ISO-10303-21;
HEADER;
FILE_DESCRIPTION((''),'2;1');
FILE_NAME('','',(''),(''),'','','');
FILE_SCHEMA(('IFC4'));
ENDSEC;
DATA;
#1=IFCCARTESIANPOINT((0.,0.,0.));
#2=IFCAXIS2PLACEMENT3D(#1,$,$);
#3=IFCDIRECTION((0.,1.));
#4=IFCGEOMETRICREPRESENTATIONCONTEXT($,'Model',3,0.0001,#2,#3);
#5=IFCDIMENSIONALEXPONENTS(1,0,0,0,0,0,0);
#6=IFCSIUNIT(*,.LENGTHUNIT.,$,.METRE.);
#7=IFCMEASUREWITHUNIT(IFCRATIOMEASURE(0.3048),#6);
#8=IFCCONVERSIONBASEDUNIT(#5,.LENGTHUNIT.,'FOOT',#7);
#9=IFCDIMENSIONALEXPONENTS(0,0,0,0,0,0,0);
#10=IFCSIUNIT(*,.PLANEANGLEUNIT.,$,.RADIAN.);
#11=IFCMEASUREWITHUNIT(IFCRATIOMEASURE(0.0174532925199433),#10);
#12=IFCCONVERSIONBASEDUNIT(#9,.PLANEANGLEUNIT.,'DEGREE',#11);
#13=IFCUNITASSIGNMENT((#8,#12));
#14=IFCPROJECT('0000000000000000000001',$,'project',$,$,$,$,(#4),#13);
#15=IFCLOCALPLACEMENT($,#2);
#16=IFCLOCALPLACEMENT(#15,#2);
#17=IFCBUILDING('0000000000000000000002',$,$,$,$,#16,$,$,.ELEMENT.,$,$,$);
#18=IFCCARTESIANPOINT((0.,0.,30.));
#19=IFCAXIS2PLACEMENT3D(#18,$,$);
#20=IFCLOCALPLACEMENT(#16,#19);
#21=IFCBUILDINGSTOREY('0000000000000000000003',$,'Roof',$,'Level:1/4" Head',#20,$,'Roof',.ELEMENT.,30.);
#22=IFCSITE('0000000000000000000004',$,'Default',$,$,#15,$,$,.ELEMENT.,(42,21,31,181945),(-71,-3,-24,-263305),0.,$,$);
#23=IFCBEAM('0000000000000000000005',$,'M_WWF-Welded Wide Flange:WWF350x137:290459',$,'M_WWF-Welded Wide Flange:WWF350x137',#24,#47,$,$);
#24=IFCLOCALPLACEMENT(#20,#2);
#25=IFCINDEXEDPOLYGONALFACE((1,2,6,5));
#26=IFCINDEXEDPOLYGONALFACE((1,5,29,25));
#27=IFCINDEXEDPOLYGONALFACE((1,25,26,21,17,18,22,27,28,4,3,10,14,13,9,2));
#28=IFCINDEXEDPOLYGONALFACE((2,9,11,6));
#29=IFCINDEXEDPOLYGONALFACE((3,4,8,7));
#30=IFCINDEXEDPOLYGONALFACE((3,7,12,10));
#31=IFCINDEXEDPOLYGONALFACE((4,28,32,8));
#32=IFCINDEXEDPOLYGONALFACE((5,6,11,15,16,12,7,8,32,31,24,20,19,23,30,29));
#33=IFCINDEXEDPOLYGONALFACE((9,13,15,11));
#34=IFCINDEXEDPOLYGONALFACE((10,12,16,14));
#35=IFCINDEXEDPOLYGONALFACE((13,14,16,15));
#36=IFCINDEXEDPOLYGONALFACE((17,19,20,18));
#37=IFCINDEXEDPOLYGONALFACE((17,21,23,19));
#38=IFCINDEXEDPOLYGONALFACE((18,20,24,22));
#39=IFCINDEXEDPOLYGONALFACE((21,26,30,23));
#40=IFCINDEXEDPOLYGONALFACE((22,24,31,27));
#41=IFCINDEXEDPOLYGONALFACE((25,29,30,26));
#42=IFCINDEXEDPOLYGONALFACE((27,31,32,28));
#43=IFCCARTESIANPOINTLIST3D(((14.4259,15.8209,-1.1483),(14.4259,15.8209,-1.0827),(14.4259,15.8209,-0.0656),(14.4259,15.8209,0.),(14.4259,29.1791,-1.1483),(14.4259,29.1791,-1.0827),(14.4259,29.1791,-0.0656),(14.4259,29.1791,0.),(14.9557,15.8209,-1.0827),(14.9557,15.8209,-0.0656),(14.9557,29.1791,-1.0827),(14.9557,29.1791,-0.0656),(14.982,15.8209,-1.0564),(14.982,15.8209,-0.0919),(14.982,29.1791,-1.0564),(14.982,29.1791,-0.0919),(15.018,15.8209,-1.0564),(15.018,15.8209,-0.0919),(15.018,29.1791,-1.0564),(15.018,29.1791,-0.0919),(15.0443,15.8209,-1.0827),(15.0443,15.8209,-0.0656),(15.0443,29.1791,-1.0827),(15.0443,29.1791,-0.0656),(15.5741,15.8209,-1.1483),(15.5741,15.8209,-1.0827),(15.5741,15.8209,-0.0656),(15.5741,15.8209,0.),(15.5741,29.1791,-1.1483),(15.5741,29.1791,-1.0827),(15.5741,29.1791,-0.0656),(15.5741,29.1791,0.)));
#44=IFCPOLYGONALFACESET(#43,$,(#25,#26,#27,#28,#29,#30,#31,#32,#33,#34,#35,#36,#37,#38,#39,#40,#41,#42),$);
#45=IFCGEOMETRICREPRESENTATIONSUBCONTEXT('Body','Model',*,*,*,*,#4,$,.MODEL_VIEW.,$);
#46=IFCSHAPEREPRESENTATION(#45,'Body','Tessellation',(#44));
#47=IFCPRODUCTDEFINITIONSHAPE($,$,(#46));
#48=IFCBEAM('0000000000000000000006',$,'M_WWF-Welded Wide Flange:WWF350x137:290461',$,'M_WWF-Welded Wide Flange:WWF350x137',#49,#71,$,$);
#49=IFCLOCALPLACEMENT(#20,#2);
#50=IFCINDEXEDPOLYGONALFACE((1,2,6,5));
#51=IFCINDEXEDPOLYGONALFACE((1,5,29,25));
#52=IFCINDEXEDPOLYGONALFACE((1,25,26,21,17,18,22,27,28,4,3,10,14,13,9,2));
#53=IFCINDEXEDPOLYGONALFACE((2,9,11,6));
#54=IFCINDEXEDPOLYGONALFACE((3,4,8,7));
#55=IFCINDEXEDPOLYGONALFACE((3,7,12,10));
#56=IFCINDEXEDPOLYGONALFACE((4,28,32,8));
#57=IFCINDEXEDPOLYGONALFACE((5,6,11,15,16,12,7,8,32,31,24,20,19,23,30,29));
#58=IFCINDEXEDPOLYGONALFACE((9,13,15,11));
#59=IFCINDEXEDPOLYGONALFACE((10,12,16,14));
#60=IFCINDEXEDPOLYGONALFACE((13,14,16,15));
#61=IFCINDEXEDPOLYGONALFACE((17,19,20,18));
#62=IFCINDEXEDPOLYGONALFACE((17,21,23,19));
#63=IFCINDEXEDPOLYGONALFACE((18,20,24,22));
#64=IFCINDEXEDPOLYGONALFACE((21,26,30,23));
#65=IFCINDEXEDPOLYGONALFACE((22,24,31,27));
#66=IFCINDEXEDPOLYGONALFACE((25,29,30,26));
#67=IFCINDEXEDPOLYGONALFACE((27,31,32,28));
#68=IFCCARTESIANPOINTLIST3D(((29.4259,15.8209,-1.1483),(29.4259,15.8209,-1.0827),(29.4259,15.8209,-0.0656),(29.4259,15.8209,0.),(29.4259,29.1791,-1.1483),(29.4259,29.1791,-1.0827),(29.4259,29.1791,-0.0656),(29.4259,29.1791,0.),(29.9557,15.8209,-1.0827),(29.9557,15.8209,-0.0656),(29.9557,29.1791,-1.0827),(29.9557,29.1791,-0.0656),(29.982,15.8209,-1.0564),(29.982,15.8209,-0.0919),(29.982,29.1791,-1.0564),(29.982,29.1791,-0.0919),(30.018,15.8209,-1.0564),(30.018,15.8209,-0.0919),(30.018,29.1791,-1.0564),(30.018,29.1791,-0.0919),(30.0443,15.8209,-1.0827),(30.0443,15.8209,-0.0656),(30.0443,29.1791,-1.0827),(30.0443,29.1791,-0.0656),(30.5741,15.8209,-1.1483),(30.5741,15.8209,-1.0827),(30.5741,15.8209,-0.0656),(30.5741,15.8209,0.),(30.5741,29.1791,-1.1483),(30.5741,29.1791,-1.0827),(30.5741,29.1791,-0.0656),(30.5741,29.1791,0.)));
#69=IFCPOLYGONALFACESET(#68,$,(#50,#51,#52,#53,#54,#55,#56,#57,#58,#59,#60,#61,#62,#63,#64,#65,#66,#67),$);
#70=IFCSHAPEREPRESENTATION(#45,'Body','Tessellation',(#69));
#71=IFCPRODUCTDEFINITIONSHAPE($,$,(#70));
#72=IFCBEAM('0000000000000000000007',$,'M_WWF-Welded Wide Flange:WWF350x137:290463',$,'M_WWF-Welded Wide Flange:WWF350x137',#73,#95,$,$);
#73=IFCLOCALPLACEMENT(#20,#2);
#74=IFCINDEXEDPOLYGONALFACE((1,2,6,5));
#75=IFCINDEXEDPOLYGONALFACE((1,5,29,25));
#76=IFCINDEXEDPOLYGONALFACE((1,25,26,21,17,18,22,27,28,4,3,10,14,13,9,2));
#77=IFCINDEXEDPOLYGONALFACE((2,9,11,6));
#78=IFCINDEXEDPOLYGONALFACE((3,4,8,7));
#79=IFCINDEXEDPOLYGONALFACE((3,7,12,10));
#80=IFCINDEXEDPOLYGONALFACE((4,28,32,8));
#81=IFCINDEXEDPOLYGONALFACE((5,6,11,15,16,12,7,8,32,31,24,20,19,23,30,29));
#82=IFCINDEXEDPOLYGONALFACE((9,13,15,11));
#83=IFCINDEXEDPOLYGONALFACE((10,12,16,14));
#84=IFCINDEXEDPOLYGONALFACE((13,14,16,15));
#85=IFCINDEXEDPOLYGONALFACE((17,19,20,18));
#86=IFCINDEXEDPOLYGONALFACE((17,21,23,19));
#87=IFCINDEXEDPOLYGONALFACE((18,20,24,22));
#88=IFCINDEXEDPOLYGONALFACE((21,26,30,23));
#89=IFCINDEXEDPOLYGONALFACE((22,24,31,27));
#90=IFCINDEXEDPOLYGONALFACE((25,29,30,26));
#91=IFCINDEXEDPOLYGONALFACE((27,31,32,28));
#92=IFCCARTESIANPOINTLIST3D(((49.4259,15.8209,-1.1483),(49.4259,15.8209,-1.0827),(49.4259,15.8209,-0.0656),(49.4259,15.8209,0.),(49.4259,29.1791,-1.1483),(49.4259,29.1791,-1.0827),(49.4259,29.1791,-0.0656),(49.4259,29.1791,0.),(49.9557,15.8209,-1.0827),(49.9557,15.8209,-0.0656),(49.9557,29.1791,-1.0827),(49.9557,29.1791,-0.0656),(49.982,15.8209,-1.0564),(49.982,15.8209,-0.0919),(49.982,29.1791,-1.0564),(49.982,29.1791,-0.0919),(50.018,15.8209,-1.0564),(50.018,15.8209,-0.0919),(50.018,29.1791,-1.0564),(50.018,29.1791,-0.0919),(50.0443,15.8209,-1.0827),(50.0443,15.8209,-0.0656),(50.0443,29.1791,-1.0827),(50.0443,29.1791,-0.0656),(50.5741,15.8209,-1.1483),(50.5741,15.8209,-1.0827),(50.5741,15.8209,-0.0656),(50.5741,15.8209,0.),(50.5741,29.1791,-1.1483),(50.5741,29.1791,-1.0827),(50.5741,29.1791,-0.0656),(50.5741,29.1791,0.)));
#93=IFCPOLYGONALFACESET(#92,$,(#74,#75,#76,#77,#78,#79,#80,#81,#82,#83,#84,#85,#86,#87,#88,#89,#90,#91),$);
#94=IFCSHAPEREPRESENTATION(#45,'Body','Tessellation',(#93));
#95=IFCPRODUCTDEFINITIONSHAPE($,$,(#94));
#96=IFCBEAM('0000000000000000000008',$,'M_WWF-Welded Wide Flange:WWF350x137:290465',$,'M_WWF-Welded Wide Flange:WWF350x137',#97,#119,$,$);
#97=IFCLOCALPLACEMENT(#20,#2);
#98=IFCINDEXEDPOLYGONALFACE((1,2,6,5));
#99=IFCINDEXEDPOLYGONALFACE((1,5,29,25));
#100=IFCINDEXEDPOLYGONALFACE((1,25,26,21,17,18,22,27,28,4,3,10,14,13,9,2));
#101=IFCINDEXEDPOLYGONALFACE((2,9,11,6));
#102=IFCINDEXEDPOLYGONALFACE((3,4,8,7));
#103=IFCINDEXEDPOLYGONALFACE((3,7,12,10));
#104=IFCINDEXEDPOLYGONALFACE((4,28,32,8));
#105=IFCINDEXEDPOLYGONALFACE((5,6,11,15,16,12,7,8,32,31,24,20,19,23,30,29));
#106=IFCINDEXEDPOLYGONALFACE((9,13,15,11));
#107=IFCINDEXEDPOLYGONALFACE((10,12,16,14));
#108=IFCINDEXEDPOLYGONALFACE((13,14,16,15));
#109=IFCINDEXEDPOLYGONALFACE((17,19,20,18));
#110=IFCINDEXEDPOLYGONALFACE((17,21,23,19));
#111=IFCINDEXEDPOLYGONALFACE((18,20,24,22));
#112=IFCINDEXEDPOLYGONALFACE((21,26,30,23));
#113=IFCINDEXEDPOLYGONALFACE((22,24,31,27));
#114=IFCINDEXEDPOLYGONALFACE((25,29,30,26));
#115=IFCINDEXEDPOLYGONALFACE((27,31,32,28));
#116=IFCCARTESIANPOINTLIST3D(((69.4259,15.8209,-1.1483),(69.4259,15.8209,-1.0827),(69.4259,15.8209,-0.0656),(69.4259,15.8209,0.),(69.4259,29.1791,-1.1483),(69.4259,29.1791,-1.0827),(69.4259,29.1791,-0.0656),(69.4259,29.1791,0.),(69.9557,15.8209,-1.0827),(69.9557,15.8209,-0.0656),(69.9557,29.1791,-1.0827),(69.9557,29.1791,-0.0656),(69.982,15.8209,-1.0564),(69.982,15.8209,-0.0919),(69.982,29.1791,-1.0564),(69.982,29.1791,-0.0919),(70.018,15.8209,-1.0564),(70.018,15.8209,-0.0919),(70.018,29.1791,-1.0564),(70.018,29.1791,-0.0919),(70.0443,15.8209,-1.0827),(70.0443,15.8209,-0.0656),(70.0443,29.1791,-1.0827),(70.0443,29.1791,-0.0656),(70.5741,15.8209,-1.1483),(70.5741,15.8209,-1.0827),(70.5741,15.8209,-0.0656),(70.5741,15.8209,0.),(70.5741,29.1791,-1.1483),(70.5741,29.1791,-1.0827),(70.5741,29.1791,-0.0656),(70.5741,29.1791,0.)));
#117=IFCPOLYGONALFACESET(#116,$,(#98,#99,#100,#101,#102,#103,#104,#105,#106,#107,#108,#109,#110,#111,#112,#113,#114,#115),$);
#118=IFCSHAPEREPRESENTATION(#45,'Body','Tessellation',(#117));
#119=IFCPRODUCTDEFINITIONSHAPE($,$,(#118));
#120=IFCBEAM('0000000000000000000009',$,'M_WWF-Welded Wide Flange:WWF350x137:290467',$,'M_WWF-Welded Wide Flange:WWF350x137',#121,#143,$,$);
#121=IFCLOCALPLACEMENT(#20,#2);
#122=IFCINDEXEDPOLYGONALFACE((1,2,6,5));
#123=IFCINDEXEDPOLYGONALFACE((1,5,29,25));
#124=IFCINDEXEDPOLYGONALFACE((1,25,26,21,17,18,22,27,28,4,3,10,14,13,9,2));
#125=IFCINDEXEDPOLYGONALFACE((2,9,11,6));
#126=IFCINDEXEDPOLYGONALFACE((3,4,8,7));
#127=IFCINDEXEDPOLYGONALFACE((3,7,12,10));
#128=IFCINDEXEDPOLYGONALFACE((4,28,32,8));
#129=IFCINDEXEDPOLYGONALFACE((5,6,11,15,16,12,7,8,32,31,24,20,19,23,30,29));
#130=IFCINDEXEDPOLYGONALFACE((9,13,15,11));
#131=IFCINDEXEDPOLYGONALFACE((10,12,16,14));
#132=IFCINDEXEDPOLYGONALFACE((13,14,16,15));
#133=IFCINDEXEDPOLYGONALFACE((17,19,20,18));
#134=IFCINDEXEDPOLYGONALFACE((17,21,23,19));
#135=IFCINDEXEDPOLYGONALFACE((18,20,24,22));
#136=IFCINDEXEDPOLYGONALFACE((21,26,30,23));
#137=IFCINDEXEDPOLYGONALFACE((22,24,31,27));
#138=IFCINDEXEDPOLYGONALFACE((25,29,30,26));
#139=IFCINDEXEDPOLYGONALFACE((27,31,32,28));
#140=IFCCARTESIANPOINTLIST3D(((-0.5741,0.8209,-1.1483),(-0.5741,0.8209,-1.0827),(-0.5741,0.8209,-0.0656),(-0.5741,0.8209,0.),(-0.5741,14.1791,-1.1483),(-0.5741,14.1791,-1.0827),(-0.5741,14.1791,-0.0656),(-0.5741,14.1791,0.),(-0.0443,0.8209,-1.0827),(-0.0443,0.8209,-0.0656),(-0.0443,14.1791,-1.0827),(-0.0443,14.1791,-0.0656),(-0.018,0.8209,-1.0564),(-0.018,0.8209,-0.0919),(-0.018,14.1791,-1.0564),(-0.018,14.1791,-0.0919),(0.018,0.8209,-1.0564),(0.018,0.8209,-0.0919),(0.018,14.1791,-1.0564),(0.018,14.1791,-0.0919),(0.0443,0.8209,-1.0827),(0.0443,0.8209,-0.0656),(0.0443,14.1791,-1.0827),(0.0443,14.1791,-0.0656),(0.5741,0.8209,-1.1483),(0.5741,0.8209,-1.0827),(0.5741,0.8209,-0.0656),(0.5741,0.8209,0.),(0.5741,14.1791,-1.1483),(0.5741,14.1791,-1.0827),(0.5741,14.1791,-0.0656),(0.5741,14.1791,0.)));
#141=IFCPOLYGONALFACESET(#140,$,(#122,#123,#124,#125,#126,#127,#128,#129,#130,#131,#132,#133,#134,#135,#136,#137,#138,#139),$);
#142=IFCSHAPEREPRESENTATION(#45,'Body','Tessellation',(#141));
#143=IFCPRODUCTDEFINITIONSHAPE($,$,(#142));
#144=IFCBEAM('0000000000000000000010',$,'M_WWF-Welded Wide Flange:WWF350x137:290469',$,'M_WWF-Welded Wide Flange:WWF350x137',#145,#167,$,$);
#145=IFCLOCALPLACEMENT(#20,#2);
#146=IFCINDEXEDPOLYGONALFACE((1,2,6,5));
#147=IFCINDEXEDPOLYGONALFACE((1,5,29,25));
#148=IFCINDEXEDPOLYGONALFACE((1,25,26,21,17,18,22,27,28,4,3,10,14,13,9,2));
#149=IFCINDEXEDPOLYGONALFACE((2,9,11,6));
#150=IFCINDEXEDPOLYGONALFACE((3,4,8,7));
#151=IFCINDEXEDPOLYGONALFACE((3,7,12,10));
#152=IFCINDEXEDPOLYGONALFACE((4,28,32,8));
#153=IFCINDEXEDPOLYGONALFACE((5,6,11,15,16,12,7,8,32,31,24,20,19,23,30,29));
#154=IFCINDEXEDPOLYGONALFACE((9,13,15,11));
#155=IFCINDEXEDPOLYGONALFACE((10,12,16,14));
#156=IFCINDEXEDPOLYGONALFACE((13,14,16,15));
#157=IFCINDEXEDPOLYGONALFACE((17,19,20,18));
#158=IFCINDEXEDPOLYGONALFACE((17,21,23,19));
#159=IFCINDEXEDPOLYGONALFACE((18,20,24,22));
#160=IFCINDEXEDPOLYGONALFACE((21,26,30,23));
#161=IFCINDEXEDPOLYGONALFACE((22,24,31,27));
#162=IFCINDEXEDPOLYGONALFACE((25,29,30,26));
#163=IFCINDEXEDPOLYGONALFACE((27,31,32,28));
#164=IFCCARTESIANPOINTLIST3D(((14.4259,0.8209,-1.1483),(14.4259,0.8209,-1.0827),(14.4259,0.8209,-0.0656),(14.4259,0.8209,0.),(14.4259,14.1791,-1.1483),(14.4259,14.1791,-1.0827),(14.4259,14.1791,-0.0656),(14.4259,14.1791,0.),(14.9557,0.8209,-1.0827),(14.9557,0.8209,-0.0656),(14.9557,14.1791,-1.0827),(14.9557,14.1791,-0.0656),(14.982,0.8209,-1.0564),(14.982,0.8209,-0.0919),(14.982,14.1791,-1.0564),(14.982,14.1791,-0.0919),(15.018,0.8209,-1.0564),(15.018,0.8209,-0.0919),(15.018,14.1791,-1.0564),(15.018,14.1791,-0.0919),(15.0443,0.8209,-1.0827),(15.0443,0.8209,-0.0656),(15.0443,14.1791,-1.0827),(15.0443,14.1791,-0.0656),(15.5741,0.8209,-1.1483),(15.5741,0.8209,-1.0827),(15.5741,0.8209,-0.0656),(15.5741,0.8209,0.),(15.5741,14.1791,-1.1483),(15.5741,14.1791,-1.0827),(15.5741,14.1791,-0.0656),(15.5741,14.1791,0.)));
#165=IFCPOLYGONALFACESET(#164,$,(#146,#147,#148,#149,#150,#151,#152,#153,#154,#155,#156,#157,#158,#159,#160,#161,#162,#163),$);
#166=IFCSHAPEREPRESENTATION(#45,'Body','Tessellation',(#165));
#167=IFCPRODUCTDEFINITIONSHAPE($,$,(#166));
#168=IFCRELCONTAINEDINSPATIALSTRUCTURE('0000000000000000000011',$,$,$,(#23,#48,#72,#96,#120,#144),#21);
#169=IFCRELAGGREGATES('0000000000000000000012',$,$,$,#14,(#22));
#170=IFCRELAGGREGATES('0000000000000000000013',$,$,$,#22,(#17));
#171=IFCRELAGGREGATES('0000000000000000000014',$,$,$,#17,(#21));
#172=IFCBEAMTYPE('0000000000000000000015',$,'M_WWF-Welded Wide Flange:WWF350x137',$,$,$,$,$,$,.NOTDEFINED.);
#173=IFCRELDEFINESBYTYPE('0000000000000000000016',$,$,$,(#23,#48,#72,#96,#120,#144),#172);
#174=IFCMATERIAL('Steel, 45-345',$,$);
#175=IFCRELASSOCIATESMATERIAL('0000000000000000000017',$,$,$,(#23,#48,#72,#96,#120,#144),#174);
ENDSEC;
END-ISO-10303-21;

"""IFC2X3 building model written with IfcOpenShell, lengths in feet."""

from ifc_helpers import new_model, entity, si_unit, converted_unit, direction, frame, origin, place, context, subcontext, project, spatial, polyline, outline, extrude, material, type_object, element, save


model = new_model("IFC2X3")

# Units and contexts
model_context = context("Model", 3, precision=0.0001, world=origin(), true_north=direction((0.0, 1.0)))
body_context = subcontext(model_context, "Body", "Model", "MODEL_VIEW")
ifc_project = project(units=[converted_unit("LENGTHUNIT", "FOOT", entity("IfcRatioMeasure", 0.3048), si_unit("LENGTHUNIT", "METRE"), dimensions=[1, 0, 0, 0, 0, 0, 0]), converted_unit("PLANEANGLEUNIT", "DEGREE", entity("IfcRatioMeasure", 0.0174532925199433), si_unit("PLANEANGLEUNIT", "RADIAN"), dimensions=[0, 0, 0, 0, 0, 0, 0])], contexts=[model_context])

# Site, building, storey
site_placement = place(None, origin())
site = spatial("IfcSite", under=ifc_project, at=site_placement, Name="Default", CompositionType="ELEMENT", RefLatitude=(42, 21, 31, 181945), RefLongitude=(-71, -3, -24, -263305), RefElevation=0.0)
building_placement = place(site_placement, origin())
building = spatial("IfcBuilding", under=site, at=building_placement, CompositionType="ELEMENT")
storey_placement = place(building_placement, frame((0.0, 0.0, 30.0)))
storey = spatial("IfcBuildingStorey", under=building, at=storey_placement, Name="Roof", ObjectType="Level:1/4\" Head", LongName="Roof", CompositionType="ELEMENT", Elevation=30.0)

# Beams
ifc_material = material(Name="Steel, 45-345")
beam_type = type_object("IfcBeamType", Name="M_WWF-Welded Wide Flange:WWF350x137", PredefinedType="NOTDEFINED")
beam_1_placement = place(storey_placement, frame((15.0, 15.0, 0.0), z_axis=(0.0, 0.0, 1.0), x_axis=(0.0, 1.0, 0.0)))
element("IfcBeam", 1, at=beam_1_placement, inside=storey, type_object=beam_type, material=ifc_material, Name="M_WWF-Welded Wide Flange:WWF350x137:290459", ObjectType="M_WWF-Welded Wide Flange:WWF350x137", context=body_context, shape_type="SweptSolid", body=[
    extrude(outline(polyline([(-0.5741, -0.5741), (-0.5085, -0.5741), (-0.5085, -0.0443), (-0.4823, -0.018), (0.4823, -0.018), (0.5085, -0.0443), (0.5085, -0.5741), (0.5741, -0.5741), (0.5741, 0.5741), (0.5085, 0.5741), (0.5085, 0.0443), (0.4823, 0.018), (-0.4823, 0.018), (-0.5085, 0.0443), (-0.5085, 0.5741), (-0.5741, 0.5741), (-0.5741, -0.5741)])), frame((0.8209, 0.0, -0.5741), z_axis=(1.0, 0.0, 0.0), x_axis=(0.0, 0.0, -1.0)), (0.0, 0.0, 1.0), 13.3583),
])
beam_2_placement = place(storey_placement, frame((30.0, 15.0, 0.0), z_axis=(0.0, 0.0, 1.0), x_axis=(0.0, 1.0, 0.0)))
element("IfcBeam", 2, at=beam_2_placement, inside=storey, type_object=beam_type, material=ifc_material, Name="M_WWF-Welded Wide Flange:WWF350x137:290461", ObjectType="M_WWF-Welded Wide Flange:WWF350x137", context=body_context, shape_type="SweptSolid", body=[
    extrude(outline(polyline([(-0.5741, -0.5741), (-0.5085, -0.5741), (-0.5085, -0.0443), (-0.4823, -0.018), (0.4823, -0.018), (0.5085, -0.0443), (0.5085, -0.5741), (0.5741, -0.5741), (0.5741, 0.5741), (0.5085, 0.5741), (0.5085, 0.0443), (0.4823, 0.018), (-0.4823, 0.018), (-0.5085, 0.0443), (-0.5085, 0.5741), (-0.5741, 0.5741), (-0.5741, -0.5741)])), frame((0.8209, 0.0, -0.5741), z_axis=(1.0, 0.0, 0.0), x_axis=(0.0, 0.0, -1.0)), (0.0, 0.0, 1.0), 13.3583),
])
beam_3_placement = place(storey_placement, frame((50.0, 15.0, 0.0), z_axis=(0.0, 0.0, 1.0), x_axis=(0.0, 1.0, 0.0)))
element("IfcBeam", 3, at=beam_3_placement, inside=storey, type_object=beam_type, material=ifc_material, Name="M_WWF-Welded Wide Flange:WWF350x137:290463", ObjectType="M_WWF-Welded Wide Flange:WWF350x137", context=body_context, shape_type="SweptSolid", body=[
    extrude(outline(polyline([(-0.5741, -0.5741), (-0.5085, -0.5741), (-0.5085, -0.0443), (-0.4823, -0.018), (0.4823, -0.018), (0.5085, -0.0443), (0.5085, -0.5741), (0.5741, -0.5741), (0.5741, 0.5741), (0.5085, 0.5741), (0.5085, 0.0443), (0.4823, 0.018), (-0.4823, 0.018), (-0.5085, 0.0443), (-0.5085, 0.5741), (-0.5741, 0.5741), (-0.5741, -0.5741)])), frame((0.8209, 0.0, -0.5741), z_axis=(1.0, 0.0, 0.0), x_axis=(0.0, 0.0, -1.0)), (0.0, 0.0, 1.0), 13.3583),
])
beam_4_placement = place(storey_placement, frame((70.0, 15.0, 0.0), z_axis=(0.0, 0.0, 1.0), x_axis=(0.0, 1.0, 0.0)))
element("IfcBeam", 4, at=beam_4_placement, inside=storey, type_object=beam_type, material=ifc_material, Name="M_WWF-Welded Wide Flange:WWF350x137:290465", ObjectType="M_WWF-Welded Wide Flange:WWF350x137", context=body_context, shape_type="SweptSolid", body=[
    extrude(outline(polyline([(-0.5741, -0.5741), (-0.5085, -0.5741), (-0.5085, -0.0443), (-0.4823, -0.018), (0.4823, -0.018), (0.5085, -0.0443), (0.5085, -0.5741), (0.5741, -0.5741), (0.5741, 0.5741), (0.5085, 0.5741), (0.5085, 0.0443), (0.4823, 0.018), (-0.4823, 0.018), (-0.5085, 0.0443), (-0.5085, 0.5741), (-0.5741, 0.5741), (-0.5741, -0.5741)])), frame((0.8209, 0.0, -0.5741), z_axis=(1.0, 0.0, 0.0), x_axis=(0.0, 0.0, -1.0)), (0.0, 0.0, 1.0), 13.3583),
])
beam_5_placement = place(storey_placement, frame((0.0, 0.0, 0.0), z_axis=(0.0, 0.0, 1.0), x_axis=(0.0, 1.0, 0.0)))
element("IfcBeam", 5, at=beam_5_placement, inside=storey, type_object=beam_type, material=ifc_material, Name="M_WWF-Welded Wide Flange:WWF350x137:290467", ObjectType="M_WWF-Welded Wide Flange:WWF350x137", context=body_context, shape_type="SweptSolid", body=[
    extrude(outline(polyline([(-0.5741, -0.5741), (-0.5085, -0.5741), (-0.5085, -0.0443), (-0.4823, -0.018), (0.4823, -0.018), (0.5085, -0.0443), (0.5085, -0.5741), (0.5741, -0.5741), (0.5741, 0.5741), (0.5085, 0.5741), (0.5085, 0.0443), (0.4823, 0.018), (-0.4823, 0.018), (-0.5085, 0.0443), (-0.5085, 0.5741), (-0.5741, 0.5741), (-0.5741, -0.5741)])), frame((0.8209, 0.0, -0.5741), z_axis=(1.0, 0.0, 0.0), x_axis=(0.0, 0.0, -1.0)), (0.0, 0.0, 1.0), 13.3583),
])
beam_6_placement = place(storey_placement, frame((15.0, 0.0, 0.0), z_axis=(0.0, 0.0, 1.0), x_axis=(0.0, 1.0, 0.0)))
element("IfcBeam", 6, at=beam_6_placement, inside=storey, type_object=beam_type, material=ifc_material, Name="M_WWF-Welded Wide Flange:WWF350x137:290469", ObjectType="M_WWF-Welded Wide Flange:WWF350x137", context=body_context, shape_type="SweptSolid", body=[
    extrude(outline(polyline([(-0.5741, -0.5741), (-0.5085, -0.5741), (-0.5085, -0.0443), (-0.4823, -0.018), (0.4823, -0.018), (0.5085, -0.0443), (0.5085, -0.5741), (0.5741, -0.5741), (0.5741, 0.5741), (0.5085, 0.5741), (0.5085, 0.0443), (0.4823, 0.018), (-0.4823, 0.018), (-0.5085, 0.0443), (-0.5085, 0.5741), (-0.5741, 0.5741), (-0.5741, -0.5741)])), frame((0.8209, 0.0, -0.5741), z_axis=(1.0, 0.0, 0.0), x_axis=(0.0, 0.0, -1.0)), (0.0, 0.0, 1.0), 13.3583),
])

save(model, "model.ifc")
